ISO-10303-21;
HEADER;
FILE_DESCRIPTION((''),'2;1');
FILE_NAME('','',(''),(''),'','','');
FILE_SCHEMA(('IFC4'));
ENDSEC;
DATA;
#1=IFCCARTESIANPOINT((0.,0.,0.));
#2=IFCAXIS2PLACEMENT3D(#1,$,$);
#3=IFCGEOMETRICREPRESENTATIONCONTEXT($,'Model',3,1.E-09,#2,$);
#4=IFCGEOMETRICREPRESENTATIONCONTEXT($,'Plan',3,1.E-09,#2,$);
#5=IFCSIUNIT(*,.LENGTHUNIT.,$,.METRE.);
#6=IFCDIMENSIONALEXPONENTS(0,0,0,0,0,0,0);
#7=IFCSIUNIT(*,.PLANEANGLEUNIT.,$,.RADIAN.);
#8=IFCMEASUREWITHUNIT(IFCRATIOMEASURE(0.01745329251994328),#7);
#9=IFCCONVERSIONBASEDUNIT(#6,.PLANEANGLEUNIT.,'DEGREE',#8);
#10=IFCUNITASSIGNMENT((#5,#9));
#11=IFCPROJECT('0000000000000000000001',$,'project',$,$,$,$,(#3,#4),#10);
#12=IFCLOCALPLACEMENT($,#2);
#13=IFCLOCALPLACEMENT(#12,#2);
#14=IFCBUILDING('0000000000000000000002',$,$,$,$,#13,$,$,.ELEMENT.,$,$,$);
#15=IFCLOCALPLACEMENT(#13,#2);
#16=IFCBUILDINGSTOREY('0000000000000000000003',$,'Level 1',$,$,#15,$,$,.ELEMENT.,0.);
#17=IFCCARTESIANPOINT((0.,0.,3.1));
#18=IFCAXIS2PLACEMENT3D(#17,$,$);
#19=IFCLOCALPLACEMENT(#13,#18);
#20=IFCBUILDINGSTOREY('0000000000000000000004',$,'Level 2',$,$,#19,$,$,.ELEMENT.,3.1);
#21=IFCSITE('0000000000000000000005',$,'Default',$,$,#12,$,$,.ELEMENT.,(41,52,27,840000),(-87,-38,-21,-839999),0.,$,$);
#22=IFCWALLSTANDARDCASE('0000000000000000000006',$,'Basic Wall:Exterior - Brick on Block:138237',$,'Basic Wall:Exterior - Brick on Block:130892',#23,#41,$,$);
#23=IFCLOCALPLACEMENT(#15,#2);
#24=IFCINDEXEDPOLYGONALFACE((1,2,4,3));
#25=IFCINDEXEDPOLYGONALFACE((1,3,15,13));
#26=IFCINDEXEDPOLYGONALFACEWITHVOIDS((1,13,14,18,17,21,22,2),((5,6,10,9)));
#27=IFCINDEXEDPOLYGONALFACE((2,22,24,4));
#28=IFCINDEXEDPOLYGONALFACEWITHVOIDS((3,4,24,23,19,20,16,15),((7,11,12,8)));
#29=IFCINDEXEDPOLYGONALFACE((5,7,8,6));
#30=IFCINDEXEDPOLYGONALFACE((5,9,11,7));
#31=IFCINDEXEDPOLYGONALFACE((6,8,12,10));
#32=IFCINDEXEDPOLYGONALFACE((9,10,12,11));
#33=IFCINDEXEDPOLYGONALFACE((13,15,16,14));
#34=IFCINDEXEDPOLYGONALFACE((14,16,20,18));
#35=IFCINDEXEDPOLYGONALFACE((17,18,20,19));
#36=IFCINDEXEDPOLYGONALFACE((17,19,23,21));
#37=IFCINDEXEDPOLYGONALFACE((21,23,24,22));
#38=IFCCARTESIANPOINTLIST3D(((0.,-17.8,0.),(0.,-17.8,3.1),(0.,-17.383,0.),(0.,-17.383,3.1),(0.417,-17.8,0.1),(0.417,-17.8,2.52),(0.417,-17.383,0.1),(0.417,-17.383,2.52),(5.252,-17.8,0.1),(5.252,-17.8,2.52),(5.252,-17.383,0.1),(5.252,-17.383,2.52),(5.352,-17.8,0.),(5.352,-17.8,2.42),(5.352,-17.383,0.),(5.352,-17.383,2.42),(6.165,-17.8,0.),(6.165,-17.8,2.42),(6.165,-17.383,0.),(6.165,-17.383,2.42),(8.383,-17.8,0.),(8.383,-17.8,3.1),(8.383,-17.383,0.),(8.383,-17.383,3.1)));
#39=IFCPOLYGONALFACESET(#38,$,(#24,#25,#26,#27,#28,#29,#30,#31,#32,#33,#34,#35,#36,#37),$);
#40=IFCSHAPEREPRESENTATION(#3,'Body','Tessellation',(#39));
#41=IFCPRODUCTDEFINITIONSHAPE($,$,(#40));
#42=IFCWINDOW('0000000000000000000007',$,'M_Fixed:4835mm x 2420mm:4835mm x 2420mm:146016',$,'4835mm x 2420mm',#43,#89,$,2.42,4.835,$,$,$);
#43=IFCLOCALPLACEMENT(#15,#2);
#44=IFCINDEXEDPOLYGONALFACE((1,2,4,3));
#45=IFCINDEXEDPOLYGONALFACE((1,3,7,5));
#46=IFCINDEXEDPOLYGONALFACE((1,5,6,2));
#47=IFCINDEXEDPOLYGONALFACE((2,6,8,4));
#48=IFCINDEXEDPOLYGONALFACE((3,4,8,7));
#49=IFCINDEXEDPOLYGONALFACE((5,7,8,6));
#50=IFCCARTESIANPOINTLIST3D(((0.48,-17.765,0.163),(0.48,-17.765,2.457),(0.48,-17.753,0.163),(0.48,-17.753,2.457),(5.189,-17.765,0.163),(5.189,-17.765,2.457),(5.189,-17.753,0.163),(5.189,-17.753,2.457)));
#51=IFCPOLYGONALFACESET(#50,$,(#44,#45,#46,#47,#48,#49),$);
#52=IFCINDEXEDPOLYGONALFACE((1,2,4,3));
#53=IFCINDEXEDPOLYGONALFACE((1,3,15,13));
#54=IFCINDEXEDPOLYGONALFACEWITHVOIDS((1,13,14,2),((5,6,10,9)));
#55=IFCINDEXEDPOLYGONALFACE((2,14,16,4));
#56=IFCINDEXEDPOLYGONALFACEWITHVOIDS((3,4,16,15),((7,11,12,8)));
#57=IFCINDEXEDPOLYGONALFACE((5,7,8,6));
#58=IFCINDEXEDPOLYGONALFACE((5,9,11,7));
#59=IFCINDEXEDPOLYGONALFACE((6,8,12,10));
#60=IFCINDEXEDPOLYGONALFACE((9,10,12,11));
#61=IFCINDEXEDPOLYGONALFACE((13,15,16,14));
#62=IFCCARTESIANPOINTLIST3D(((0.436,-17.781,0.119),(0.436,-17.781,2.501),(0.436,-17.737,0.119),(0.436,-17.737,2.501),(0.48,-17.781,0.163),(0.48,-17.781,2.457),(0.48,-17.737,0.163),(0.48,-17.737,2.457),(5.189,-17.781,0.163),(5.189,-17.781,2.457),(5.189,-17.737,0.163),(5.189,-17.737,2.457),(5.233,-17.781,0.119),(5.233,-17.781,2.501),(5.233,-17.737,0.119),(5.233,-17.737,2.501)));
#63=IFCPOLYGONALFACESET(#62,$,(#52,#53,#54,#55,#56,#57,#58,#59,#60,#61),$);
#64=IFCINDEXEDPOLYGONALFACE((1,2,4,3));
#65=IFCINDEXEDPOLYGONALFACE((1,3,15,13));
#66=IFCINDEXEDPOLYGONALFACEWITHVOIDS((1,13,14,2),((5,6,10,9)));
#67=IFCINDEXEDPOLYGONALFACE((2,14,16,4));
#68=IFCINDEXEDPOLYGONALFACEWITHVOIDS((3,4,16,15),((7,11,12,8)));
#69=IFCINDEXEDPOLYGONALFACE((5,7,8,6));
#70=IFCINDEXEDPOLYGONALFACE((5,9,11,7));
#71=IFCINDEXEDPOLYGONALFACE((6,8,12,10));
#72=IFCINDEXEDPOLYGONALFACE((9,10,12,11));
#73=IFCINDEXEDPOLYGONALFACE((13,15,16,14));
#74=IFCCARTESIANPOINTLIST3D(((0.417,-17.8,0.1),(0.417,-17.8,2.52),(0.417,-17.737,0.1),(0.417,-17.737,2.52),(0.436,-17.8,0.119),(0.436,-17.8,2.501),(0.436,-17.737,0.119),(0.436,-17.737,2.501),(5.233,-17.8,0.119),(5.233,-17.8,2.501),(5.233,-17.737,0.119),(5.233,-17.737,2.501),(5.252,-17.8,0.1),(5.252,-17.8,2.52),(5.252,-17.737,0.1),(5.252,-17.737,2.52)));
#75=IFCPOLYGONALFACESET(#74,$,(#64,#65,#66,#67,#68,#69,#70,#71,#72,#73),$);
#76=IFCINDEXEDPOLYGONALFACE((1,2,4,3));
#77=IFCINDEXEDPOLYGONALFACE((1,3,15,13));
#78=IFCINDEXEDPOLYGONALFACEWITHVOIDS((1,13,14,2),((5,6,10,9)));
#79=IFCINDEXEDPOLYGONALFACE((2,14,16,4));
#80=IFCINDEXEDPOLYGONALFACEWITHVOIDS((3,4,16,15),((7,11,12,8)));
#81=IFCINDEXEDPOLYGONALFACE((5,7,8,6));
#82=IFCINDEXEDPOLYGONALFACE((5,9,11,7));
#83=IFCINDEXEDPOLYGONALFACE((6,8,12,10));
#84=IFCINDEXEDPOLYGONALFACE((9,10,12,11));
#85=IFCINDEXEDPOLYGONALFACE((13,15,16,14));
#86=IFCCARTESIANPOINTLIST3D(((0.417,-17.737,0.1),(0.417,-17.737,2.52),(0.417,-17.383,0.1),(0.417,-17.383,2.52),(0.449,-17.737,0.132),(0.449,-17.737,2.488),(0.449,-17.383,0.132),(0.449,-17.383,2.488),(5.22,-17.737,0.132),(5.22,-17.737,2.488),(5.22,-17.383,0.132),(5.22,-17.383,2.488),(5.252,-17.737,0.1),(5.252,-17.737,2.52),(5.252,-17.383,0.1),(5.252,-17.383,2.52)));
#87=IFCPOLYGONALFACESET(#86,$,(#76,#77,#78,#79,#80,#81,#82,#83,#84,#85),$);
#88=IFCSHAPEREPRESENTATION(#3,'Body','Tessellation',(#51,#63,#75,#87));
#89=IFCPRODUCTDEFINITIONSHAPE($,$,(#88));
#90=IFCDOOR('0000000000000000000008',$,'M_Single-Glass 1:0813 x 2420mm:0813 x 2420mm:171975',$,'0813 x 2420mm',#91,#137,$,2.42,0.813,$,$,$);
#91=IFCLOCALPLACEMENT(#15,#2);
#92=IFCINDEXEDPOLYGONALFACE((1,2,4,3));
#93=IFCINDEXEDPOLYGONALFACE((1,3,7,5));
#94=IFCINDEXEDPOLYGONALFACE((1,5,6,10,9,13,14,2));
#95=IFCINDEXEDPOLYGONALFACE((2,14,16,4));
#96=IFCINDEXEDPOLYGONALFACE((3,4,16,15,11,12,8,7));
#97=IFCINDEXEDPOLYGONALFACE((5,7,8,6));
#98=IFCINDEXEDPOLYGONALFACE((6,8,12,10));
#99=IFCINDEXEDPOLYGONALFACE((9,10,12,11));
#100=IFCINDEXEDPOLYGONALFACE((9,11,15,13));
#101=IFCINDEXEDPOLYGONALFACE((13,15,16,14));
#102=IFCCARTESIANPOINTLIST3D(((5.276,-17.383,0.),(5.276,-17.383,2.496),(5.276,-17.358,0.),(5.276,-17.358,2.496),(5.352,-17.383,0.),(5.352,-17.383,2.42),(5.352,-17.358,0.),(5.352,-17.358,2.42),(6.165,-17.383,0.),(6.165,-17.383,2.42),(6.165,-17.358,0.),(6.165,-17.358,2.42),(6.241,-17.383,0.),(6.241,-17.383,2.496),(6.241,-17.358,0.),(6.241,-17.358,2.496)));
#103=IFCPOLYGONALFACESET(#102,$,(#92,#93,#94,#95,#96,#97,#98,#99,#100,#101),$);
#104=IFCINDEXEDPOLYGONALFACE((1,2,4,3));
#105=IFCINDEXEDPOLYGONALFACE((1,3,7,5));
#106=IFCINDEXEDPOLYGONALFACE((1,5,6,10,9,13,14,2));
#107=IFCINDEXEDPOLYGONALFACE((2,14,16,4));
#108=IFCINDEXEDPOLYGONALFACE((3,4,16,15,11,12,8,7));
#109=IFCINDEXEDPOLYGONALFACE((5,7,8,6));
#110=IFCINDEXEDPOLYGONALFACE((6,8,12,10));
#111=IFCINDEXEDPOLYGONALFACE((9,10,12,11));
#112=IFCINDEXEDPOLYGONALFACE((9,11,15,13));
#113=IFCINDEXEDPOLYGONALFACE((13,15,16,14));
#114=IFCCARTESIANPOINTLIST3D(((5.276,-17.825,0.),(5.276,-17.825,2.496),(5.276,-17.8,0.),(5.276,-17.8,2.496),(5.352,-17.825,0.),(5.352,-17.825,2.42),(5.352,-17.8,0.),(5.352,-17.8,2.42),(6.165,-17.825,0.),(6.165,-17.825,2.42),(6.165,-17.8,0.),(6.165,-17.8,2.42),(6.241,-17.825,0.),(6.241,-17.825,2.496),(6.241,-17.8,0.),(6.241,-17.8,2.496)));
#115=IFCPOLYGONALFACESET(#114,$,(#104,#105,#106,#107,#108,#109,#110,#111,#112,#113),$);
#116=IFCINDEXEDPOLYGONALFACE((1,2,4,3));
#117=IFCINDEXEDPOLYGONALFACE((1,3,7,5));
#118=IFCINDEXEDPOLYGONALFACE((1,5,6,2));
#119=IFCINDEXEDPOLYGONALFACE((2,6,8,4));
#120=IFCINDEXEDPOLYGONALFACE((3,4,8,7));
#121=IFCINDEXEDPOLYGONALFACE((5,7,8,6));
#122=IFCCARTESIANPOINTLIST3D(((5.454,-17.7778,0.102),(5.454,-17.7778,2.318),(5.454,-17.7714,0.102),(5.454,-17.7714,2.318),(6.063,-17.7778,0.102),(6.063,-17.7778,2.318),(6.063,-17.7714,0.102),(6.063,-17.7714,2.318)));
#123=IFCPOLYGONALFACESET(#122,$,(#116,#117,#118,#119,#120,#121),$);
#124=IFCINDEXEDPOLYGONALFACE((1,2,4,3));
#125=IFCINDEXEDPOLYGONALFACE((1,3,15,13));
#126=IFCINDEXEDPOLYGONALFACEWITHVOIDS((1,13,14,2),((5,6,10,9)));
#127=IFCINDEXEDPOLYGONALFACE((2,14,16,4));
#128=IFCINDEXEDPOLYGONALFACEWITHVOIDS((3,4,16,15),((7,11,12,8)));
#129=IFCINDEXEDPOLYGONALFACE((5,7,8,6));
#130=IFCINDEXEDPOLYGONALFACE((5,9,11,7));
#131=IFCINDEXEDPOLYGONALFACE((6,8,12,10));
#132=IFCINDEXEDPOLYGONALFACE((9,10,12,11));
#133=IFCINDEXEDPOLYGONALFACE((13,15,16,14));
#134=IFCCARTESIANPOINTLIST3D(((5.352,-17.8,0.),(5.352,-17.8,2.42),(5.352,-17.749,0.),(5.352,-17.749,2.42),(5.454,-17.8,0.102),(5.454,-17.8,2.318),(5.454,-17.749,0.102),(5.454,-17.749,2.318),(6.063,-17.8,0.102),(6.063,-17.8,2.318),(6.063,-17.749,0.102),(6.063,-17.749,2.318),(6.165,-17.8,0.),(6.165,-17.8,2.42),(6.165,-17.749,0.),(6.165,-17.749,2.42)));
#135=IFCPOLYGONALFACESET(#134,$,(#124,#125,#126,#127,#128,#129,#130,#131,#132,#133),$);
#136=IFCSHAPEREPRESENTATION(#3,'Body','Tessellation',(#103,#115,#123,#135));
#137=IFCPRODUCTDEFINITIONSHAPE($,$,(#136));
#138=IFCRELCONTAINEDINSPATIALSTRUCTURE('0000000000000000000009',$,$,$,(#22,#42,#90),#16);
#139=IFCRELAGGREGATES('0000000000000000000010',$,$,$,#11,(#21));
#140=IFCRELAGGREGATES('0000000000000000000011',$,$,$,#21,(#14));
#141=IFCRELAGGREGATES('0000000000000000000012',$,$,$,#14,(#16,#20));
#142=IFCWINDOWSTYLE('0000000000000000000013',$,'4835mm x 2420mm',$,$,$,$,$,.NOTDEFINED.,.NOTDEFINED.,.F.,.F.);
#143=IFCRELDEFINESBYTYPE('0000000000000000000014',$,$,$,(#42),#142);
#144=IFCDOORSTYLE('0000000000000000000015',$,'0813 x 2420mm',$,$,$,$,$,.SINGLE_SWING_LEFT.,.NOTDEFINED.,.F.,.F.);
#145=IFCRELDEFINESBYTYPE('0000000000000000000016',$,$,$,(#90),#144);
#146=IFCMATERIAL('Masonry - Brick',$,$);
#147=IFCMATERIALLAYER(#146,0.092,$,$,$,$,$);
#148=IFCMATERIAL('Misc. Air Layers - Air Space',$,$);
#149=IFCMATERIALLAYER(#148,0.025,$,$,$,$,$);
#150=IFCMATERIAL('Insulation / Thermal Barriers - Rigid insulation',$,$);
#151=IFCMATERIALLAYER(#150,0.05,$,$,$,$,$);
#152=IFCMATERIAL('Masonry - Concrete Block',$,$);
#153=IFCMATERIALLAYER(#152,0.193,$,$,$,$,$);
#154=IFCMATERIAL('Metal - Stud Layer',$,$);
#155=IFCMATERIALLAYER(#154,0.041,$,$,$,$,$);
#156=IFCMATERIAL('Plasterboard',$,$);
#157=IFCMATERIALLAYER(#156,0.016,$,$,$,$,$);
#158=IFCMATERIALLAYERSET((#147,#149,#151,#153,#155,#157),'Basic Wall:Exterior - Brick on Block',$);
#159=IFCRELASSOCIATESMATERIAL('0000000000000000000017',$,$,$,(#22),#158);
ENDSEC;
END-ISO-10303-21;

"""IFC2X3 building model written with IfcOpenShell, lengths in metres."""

from ifc_helpers import new_model, entity, si_unit, converted_unit, frame, frame_2d, origin, origin_2d_with_axis, place, context, project, spatial, polyline, rectangle, outline, extrude, source, transform, mapped, material, layer, layer_set, layer_usage, type_object, type_shapes, element, fill, save


model = new_model("IFC2X3")

# Units and contexts
model_context = context("Model", 3, precision=1e-09, world=origin())
plan_context = context("Plan", 3, precision=1e-09, world=origin())
ifc_project = project(units=[si_unit("LENGTHUNIT", "METRE"), converted_unit("PLANEANGLEUNIT", "DEGREE", entity("IfcRatioMeasure", 0.01745329251994328), si_unit("PLANEANGLEUNIT", "RADIAN"), dimensions=[0, 0, 0, 0, 0, 0, 0])], contexts=[model_context, plan_context])

# Site, building, storey
site_placement = place(None, origin())
site = spatial("IfcSite", under=ifc_project, at=site_placement, Name="Default", CompositionType="ELEMENT", RefLatitude=(41, 52, 27, 840000), RefLongitude=(-87, -38, -21, -839999), RefElevation=0.0)
building_placement = place(site_placement, origin())
building = spatial("IfcBuilding", under=site, at=building_placement, CompositionType="ELEMENT")
storey_1_placement = place(building_placement, origin())
storey_1 = spatial("IfcBuildingStorey", under=building, at=storey_1_placement, Name="Level 1", CompositionType="ELEMENT", Elevation=0.0)

# Wall, openings, window, door
ifc_material_1 = material(Name="Masonry - Brick")
ifc_layer_1 = layer(ifc_material_1, 0.092)
ifc_material_2 = material(Name="Misc. Air Layers - Air Space")
ifc_layer_2 = layer(ifc_material_2, 0.025)
ifc_material_3 = material(Name="Insulation / Thermal Barriers - Rigid insulation")
ifc_layer_3 = layer(ifc_material_3, 0.05)
ifc_material_4 = material(Name="Masonry - Concrete Block")
ifc_layer_4 = layer(ifc_material_4, 0.193)
ifc_material_5 = material(Name="Metal - Stud Layer")
ifc_layer_5 = layer(ifc_material_5, 0.041)
ifc_material_6 = material(Name="Plasterboard")
ifc_layer_6 = layer(ifc_material_6, 0.016)
ifc_layer_set_1 = layer_set([ifc_layer_1, ifc_layer_2, ifc_layer_3, ifc_layer_4, ifc_layer_5, ifc_layer_6], Name="Basic Wall:Exterior - Brick on Block")
ifc_layer_usage_1 = layer_usage(ifc_layer_set_1, "AXIS2", "NEGATIVE", 0.2085)
wall_1_placement = place(storey_1_placement, frame((8.383, -17.5915, 0.0), z_axis=(0.0, 0.0, 1.0), x_axis=(-1.0, 0.0, 0.0)))
wall_1 = element("IfcWallStandardCase", 1, at=wall_1_placement, inside=storey_1, material=ifc_layer_usage_1, Name="Basic Wall:Exterior - Brick on Block:138237", ObjectType="Basic Wall:Exterior - Brick on Block:130892", context=model_context, shape_type="SweptSolid", body=[
    extrude(rectangle(XDim=8.383, YDim=0.417, at=frame_2d((4.1915, 0.0), x_axis=(-1.0, 0.0))), origin(), (0.0, 0.0, 1.0), 3.1),
])
opening_1_placement = place(wall_1_placement, frame((3.131, -0.2085, 0.1)))
opening_1 = element("IfcOpeningElement", 2, at=opening_1_placement, cuts=wall_1, ObjectType="Opening", context=model_context, shape_type="SweptSolid", body=[
    extrude(rectangle(XDim=2.42, YDim=4.835, at=frame_2d((1.21, 2.4175), x_axis=(1.0, 0.0))), frame((0.0, 0.0, 0.0), z_axis=(0.0, 1.0, 0.0), x_axis=(0.0, 0.0, 1.0)), (0.0, 0.0, 1.0), 0.417),
])
opening_2_placement = place(wall_1_placement, frame((2.218, -0.2085, 0.0)))
opening_2 = element("IfcOpeningElement", 3, at=opening_2_placement, cuts=wall_1, ObjectType="Opening", context=model_context, shape_type="SweptSolid", body=[
    extrude(rectangle(XDim=0.813, YDim=2.42, at=frame_2d((1.21, 0.4065), x_axis=(0.0, -1.0))), frame((0.0, 0.0, 0.0), z_axis=(0.0, 1.0, 0.0), x_axis=(0.0, 0.0, 1.0)), (0.0, 0.0, 1.0), 0.417),
])
window_style_1 = type_object("IfcWindowStyle", Name="4835mm x 2420mm", ConstructionType="NOTDEFINED", OperationType="NOTDEFINED", ParameterTakesPrecedence=False, Sizeable=False)
shared_shape_1 = source(origin(), model_context, "Body", "SweptSolid", [
    extrude(rectangle(XDim=0.012, YDim=4.709, at=origin_2d_with_axis()), frame((2.4175, 0.376, 0.063), z_axis=(0.0, 0.0, 1.0), x_axis=(0.0, -1.0, 0.0)), (0.0, 0.0, 1.0), 2.294),
    extrude(outline(polyline([(-2.3985, -1.191), (2.3985, -1.191), (2.3985, 1.191), (-2.3985, 1.191), (-2.3985, -1.191)]), holes=[polyline([(-2.3545, -1.147), (-2.3545, 1.147), (2.3545, 1.147), (2.3545, -1.147), (-2.3545, -1.147)])]), frame((2.4175, 0.354, 1.21), z_axis=(0.0, 1.0, 0.0), x_axis=(1.0, 0.0, 0.0)), (0.0, 0.0, 1.0), 0.044),
    extrude(outline(polyline([(-2.4175, -1.21), (2.4175, -1.21), (2.4175, 1.21), (-2.4175, 1.21), (-2.4175, -1.21)]), holes=[polyline([(-2.3985, -1.191), (-2.3985, 1.191), (2.3985, 1.191), (2.3985, -1.191), (-2.3985, -1.191)])]), frame((2.4175, 0.354, 1.21), z_axis=(0.0, 1.0, 0.0), x_axis=(1.0, 0.0, 0.0)), (0.0, 0.0, 1.0), 0.063),
    extrude(outline(polyline([(-2.4175, -1.21), (2.4175, -1.21), (2.4175, 1.21), (-2.4175, 1.21), (-2.4175, -1.21)]), holes=[polyline([(-2.3855, -1.178), (-2.3855, 1.178), (2.3855, 1.178), (2.3855, -1.178), (-2.3855, -1.178)])]), frame((2.4175, 0.0, 1.21), z_axis=(0.0, 1.0, 0.0), x_axis=(1.0, 0.0, 0.0)), (0.0, 0.0, 1.0), 0.354),
])
type_shapes(window_style_1, [shared_shape_1])
window_1_placement = place(opening_1_placement, origin())
window_1 = element("IfcWindow", 4, at=window_1_placement, inside=storey_1, type_object=window_style_1, Name="M_Fixed:4835mm x 2420mm:4835mm x 2420mm:146016", ObjectType="4835mm x 2420mm", OverallHeight=2.42, OverallWidth=4.835, context=model_context, shape_type="MappedRepresentation", body=[
    mapped(shared_shape_1, transform((0.0, 0.0, 0.0), scale=1.0)),
])
fill(opening_1, window_1)
door_style_1 = type_object("IfcDoorStyle", Name="0813 x 2420mm", ConstructionType="NOTDEFINED", OperationType="SINGLE_SWING_LEFT", ParameterTakesPrecedence=False, Sizeable=False)
shared_shape_2 = source(origin(), model_context, "Body", "SweptSolid", [
    extrude(outline(polyline([(-0.4065, -1.191), (-0.4065, 1.229), (-0.4825, 1.229), (-0.4825, -1.267), (0.4825, -1.267), (0.4825, 1.229), (0.4065, 1.229), (0.4065, -1.191), (-0.4065, -1.191)])), frame((0.4065, 0.0, 1.229), z_axis=(0.0, 1.0, 0.0), x_axis=(1.0, 0.0, 0.0)), (0.0, 0.0, -1.0), 0.025),
    extrude(outline(polyline([(-0.4065, -1.191), (-0.4065, 1.229), (-0.4825, 1.229), (-0.4825, -1.267), (0.4825, -1.267), (0.4825, 1.229), (0.4065, 1.229), (0.4065, -1.191), (-0.4065, -1.191)])), frame((0.4065, 0.442, 1.229), z_axis=(0.0, 1.0, 0.0), x_axis=(1.0, 0.0, 0.0)), (0.0, 0.0, -1.0), 0.025),
    extrude(rectangle(XDim=0.609, YDim=0.0064, at=origin_2d_with_axis()), frame((0.4065, 0.3916, 0.102)), (0.0, 0.0, 1.0), 2.216),
    extrude(outline(polyline([(-1.21, -0.4065), (1.21, -0.4065), (1.21, 0.4065), (-1.21, 0.4065), (-1.21, -0.4065)]), holes=[polyline([(-1.108, 0.3045), (1.108, 0.3045), (1.108, -0.3045), (-1.108, -0.3045), (-1.108, 0.3045)])]), frame((0.4065, 0.417, 1.21), z_axis=(0.0, -1.0, 0.0), x_axis=(0.0, 0.0, -1.0)), (0.0, 0.0, 1.0), 0.051),
])
type_shapes(door_style_1, [shared_shape_2])
door_1_placement = place(opening_2_placement, origin())
door_1 = element("IfcDoor", 5, at=door_1_placement, inside=storey_1, type_object=door_style_1, Name="M_Single-Glass 1:0813 x 2420mm:0813 x 2420mm:171975", ObjectType="0813 x 2420mm", OverallHeight=2.42, OverallWidth=0.813, context=model_context, shape_type="MappedRepresentation", body=[
    mapped(shared_shape_2, transform((0.0, 0.0, 0.0), scale=1.0)),
])
fill(opening_2, door_1)

# Shared definitions
storey_2_placement = place(building_placement, frame((0.0, 0.0, 3.1)))
storey_2 = spatial("IfcBuildingStorey", under=building, at=storey_2_placement, Name="Level 2", CompositionType="ELEMENT", Elevation=3.1)

save(model, "model.ifc")
